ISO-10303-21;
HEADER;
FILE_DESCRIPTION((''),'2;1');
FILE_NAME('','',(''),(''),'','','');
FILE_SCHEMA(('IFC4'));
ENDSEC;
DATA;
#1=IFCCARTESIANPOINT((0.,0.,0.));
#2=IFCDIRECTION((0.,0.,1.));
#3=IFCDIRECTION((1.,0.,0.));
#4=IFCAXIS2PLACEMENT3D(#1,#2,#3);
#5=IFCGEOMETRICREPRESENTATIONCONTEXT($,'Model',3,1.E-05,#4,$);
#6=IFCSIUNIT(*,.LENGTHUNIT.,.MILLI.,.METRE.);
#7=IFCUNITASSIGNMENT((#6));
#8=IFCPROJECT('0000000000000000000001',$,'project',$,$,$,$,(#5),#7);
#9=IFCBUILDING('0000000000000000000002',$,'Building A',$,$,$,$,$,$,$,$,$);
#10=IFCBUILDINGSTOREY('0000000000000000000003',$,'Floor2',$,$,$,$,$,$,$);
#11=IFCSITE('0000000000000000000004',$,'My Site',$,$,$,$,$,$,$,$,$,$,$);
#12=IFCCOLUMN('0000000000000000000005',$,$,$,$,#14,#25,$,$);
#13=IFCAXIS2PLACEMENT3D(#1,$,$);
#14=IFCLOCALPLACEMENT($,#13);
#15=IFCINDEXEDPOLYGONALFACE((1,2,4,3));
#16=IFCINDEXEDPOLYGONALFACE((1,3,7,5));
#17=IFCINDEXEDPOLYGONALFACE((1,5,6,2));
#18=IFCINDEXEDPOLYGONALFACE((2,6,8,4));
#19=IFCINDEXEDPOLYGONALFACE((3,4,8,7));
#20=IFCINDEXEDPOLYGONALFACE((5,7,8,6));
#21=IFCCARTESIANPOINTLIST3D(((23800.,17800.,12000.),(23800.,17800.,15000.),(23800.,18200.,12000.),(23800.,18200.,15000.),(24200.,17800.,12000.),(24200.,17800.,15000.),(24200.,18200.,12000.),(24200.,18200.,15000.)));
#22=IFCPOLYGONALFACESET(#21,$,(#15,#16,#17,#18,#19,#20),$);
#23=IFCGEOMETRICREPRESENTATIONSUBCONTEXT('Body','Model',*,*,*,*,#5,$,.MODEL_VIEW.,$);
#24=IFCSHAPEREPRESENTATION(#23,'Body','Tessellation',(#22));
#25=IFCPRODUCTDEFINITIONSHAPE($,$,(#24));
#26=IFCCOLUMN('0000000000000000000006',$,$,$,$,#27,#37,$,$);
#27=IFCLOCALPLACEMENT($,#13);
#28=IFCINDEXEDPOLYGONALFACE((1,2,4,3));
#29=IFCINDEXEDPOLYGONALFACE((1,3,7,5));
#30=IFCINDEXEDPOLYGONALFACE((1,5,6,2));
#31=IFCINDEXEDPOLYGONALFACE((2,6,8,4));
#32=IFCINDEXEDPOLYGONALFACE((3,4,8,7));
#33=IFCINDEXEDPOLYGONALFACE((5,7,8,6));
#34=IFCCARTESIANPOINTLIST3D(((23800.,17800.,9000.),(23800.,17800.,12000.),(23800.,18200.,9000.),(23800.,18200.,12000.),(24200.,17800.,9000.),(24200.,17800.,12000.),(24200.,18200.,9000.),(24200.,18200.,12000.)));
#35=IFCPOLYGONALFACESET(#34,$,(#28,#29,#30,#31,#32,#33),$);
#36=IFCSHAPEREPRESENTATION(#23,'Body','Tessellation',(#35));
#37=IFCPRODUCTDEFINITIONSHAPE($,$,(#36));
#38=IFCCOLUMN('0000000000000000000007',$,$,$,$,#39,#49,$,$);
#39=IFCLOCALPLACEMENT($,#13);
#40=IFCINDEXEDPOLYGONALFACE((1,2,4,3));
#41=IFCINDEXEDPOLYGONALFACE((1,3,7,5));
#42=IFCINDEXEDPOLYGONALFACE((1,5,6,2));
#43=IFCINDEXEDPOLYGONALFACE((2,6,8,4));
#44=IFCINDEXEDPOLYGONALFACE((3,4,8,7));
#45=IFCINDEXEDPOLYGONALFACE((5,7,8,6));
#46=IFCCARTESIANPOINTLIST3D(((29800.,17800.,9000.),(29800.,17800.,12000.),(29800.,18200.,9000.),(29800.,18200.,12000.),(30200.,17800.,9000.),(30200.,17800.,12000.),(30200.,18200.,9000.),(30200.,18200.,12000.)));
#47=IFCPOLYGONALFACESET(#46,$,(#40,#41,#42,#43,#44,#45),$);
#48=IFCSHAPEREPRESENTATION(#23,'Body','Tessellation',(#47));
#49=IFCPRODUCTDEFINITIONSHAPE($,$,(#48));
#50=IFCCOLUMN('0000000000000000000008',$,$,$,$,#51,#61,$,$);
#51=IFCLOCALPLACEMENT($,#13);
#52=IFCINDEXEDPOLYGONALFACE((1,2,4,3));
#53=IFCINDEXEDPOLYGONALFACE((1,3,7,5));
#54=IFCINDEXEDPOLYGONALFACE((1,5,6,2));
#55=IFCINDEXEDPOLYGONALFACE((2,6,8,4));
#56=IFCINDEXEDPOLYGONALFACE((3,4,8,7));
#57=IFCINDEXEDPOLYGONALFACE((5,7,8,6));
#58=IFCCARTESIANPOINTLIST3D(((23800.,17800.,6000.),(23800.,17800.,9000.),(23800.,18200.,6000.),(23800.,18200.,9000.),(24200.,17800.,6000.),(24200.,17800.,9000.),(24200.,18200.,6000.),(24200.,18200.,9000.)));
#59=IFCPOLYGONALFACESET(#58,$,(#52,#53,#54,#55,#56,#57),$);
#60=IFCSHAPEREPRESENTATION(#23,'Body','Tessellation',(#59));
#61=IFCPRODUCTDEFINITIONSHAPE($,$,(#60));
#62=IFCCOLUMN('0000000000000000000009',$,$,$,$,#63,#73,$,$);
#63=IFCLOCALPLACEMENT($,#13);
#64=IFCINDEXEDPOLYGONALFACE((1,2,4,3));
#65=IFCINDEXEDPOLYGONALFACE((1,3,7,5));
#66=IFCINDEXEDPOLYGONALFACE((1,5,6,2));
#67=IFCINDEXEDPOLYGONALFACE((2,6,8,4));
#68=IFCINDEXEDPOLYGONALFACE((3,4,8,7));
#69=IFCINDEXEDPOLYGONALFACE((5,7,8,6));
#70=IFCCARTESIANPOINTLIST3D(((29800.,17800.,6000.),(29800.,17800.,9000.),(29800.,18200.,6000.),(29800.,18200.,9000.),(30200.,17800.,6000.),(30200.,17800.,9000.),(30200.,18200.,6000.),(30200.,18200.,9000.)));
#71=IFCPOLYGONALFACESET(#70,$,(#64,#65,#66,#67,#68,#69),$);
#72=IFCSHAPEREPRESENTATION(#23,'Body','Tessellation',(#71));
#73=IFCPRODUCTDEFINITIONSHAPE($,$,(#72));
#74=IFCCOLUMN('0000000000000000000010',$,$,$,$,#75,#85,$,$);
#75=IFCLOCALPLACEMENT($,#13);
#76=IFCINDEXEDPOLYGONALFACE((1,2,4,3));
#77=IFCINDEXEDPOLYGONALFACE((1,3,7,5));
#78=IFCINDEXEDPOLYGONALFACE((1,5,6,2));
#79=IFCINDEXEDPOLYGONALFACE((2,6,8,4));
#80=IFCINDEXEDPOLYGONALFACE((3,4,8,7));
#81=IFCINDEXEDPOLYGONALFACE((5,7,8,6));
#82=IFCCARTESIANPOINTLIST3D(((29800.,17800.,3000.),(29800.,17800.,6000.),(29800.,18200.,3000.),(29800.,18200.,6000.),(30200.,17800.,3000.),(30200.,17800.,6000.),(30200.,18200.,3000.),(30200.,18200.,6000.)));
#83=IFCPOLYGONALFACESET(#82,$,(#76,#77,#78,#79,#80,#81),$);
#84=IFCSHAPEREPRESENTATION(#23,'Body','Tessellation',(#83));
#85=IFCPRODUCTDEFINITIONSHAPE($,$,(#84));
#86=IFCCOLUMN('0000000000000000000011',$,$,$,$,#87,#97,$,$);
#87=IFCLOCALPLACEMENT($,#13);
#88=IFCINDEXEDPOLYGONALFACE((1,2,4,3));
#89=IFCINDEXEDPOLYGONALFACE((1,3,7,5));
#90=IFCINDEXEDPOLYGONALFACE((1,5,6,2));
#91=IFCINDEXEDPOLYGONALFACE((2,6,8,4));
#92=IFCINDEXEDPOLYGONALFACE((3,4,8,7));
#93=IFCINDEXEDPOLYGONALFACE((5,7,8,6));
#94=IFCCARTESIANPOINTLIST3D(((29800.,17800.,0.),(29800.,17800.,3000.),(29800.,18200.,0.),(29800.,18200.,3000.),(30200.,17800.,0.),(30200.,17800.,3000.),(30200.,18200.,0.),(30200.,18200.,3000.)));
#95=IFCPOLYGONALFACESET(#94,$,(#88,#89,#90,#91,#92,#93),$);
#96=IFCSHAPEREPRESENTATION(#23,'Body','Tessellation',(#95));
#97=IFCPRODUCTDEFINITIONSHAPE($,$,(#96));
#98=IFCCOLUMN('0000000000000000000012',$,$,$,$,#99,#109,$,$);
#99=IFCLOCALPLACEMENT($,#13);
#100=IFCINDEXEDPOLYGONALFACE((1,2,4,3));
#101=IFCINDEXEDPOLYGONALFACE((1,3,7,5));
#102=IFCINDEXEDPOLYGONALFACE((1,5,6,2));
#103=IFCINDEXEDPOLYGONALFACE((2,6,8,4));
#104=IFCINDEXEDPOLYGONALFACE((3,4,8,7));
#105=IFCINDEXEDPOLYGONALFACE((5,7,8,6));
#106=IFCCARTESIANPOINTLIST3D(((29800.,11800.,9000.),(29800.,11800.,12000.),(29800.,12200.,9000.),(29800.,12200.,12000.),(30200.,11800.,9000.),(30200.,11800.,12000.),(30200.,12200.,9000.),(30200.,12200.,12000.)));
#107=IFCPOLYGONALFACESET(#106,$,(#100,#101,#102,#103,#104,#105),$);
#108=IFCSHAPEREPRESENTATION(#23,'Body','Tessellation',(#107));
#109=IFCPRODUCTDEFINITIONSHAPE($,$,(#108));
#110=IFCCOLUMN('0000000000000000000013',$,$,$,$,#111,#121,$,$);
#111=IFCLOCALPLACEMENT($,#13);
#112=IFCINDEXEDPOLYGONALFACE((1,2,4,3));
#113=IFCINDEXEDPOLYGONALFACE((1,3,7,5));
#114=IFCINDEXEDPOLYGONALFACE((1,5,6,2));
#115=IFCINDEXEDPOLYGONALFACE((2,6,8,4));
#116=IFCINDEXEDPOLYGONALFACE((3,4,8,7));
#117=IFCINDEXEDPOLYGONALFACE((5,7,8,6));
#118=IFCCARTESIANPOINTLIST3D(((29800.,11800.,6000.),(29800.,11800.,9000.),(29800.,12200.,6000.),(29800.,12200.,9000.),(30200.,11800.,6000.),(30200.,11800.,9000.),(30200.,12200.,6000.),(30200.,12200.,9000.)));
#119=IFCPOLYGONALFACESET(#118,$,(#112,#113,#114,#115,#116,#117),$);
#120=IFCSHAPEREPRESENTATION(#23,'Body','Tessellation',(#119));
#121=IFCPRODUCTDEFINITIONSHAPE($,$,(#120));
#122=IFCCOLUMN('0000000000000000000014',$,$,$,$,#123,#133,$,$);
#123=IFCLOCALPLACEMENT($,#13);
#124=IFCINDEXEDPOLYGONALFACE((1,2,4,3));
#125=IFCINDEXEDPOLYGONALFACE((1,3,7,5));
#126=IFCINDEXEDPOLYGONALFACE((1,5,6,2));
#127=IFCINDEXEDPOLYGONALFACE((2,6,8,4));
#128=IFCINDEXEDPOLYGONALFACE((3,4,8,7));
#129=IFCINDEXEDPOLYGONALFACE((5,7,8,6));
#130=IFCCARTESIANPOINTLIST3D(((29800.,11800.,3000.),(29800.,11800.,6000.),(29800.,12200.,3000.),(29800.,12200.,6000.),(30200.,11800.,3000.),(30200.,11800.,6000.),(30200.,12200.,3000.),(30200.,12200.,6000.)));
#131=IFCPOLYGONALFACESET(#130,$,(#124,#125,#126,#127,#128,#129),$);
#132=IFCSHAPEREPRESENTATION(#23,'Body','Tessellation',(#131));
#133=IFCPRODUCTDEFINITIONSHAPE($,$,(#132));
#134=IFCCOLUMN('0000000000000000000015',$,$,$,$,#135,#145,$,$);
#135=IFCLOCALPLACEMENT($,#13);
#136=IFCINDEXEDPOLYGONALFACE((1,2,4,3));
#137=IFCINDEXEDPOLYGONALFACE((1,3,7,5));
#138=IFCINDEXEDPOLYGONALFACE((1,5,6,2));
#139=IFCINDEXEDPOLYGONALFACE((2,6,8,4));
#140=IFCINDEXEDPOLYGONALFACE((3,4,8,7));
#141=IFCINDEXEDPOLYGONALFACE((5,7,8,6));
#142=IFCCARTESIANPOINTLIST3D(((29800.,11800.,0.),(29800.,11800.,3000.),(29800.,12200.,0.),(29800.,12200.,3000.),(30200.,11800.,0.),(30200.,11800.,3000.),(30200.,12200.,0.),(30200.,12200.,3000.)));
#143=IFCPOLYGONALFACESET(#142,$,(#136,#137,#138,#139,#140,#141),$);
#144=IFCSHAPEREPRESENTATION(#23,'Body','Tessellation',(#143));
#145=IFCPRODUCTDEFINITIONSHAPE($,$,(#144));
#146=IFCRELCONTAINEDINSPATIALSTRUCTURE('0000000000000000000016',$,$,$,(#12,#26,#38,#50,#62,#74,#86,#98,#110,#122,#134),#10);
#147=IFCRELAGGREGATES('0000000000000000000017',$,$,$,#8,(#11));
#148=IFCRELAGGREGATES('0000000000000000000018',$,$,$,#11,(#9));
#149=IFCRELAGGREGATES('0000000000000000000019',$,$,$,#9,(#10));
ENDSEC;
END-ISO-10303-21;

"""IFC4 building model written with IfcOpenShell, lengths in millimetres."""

from ifc_helpers import new_model, si_unit, frame, origin_with_axes, place, context, subcontext, project, spatial, line, indexed_curve, outline, extrude, element, save


model = new_model("IFC4")

# Units and contexts
model_context = context("Model", 3, precision=1e-05, world=origin_with_axes())
body_context = subcontext(model_context, "Body", "Model", "MODEL_VIEW")
ifc_project = project(units=[si_unit("LENGTHUNIT", "METRE", prefix="MILLI")], contexts=[model_context])

# Site, building, storey
site = spatial("IfcSite", under=ifc_project, Name="My Site")
building = spatial("IfcBuilding", under=site, Name="Building A")
storey = spatial("IfcBuildingStorey", under=building, Name="Floor2")

# Columns
for number, where, z_axis, x_axis in (
    (1, (24000.0, 18000.0, 12000.0), (0.0, 0.0, 1.0), (1.0, 0.0, 0.0)),
    (2, (24000.0, 18000.0, 9000.0), (0.0, 0.0, 1.0), (1.0, 0.0, 0.0)),
    (3, (30000.0, 18000.0, 9000.0), (0.0, 0.0, 1.0), (1.0, 0.0, 0.0)),
    (4, (24000.0, 18000.0, 6000.0), (0.0, 0.0, 1.0), (1.0, 0.0, 0.0)),
    (5, (30000.0, 18000.0, 6000.0), (0.0, 0.0, 1.0), (1.0, 0.0, 0.0)),
    (6, (30000.0, 18000.0, 3000.0), (0.0, 0.0, 1.0), (1.0, 0.0, 0.0)),
    (7, (30000.0, 18000.0, 0.0), (0.0, 0.0, 1.0), (1.0, 0.0, 0.0)),
    (8, (30000.0, 12000.0, 9000.0), (0.0, 0.0, 1.0), (1.0, 0.0, 0.0)),
    (9, (30000.0, 12000.0, 6000.0), (0.0, 0.0, 1.0), (1.0, 0.0, 0.0)),
    (10, (30000.0, 12000.0, 3000.0), (0.0, 0.0, 1.0), (1.0, 0.0, 0.0)),
    (11, (30000.0, 12000.0, 0.0), (0.0, 0.0, 1.0), (1.0, 0.0, 0.0)),
):
    element("IfcColumn", number, at=place(None, frame(where, z_axis=z_axis, x_axis=x_axis)), inside=storey, context=body_context, shape_type="SweptSolid", body=[
        extrude(outline(indexed_curve([(-200.0, -200.0), (200.0, -200.0), (200.0, 200.0), (-200.0, 200.0)], segments=[line(1, 2, 3, 4, 1)])), origin_with_axes(), (0.0, 0.0, 1.0), 3000.0),
    ])

save(model, "model.ifc")
